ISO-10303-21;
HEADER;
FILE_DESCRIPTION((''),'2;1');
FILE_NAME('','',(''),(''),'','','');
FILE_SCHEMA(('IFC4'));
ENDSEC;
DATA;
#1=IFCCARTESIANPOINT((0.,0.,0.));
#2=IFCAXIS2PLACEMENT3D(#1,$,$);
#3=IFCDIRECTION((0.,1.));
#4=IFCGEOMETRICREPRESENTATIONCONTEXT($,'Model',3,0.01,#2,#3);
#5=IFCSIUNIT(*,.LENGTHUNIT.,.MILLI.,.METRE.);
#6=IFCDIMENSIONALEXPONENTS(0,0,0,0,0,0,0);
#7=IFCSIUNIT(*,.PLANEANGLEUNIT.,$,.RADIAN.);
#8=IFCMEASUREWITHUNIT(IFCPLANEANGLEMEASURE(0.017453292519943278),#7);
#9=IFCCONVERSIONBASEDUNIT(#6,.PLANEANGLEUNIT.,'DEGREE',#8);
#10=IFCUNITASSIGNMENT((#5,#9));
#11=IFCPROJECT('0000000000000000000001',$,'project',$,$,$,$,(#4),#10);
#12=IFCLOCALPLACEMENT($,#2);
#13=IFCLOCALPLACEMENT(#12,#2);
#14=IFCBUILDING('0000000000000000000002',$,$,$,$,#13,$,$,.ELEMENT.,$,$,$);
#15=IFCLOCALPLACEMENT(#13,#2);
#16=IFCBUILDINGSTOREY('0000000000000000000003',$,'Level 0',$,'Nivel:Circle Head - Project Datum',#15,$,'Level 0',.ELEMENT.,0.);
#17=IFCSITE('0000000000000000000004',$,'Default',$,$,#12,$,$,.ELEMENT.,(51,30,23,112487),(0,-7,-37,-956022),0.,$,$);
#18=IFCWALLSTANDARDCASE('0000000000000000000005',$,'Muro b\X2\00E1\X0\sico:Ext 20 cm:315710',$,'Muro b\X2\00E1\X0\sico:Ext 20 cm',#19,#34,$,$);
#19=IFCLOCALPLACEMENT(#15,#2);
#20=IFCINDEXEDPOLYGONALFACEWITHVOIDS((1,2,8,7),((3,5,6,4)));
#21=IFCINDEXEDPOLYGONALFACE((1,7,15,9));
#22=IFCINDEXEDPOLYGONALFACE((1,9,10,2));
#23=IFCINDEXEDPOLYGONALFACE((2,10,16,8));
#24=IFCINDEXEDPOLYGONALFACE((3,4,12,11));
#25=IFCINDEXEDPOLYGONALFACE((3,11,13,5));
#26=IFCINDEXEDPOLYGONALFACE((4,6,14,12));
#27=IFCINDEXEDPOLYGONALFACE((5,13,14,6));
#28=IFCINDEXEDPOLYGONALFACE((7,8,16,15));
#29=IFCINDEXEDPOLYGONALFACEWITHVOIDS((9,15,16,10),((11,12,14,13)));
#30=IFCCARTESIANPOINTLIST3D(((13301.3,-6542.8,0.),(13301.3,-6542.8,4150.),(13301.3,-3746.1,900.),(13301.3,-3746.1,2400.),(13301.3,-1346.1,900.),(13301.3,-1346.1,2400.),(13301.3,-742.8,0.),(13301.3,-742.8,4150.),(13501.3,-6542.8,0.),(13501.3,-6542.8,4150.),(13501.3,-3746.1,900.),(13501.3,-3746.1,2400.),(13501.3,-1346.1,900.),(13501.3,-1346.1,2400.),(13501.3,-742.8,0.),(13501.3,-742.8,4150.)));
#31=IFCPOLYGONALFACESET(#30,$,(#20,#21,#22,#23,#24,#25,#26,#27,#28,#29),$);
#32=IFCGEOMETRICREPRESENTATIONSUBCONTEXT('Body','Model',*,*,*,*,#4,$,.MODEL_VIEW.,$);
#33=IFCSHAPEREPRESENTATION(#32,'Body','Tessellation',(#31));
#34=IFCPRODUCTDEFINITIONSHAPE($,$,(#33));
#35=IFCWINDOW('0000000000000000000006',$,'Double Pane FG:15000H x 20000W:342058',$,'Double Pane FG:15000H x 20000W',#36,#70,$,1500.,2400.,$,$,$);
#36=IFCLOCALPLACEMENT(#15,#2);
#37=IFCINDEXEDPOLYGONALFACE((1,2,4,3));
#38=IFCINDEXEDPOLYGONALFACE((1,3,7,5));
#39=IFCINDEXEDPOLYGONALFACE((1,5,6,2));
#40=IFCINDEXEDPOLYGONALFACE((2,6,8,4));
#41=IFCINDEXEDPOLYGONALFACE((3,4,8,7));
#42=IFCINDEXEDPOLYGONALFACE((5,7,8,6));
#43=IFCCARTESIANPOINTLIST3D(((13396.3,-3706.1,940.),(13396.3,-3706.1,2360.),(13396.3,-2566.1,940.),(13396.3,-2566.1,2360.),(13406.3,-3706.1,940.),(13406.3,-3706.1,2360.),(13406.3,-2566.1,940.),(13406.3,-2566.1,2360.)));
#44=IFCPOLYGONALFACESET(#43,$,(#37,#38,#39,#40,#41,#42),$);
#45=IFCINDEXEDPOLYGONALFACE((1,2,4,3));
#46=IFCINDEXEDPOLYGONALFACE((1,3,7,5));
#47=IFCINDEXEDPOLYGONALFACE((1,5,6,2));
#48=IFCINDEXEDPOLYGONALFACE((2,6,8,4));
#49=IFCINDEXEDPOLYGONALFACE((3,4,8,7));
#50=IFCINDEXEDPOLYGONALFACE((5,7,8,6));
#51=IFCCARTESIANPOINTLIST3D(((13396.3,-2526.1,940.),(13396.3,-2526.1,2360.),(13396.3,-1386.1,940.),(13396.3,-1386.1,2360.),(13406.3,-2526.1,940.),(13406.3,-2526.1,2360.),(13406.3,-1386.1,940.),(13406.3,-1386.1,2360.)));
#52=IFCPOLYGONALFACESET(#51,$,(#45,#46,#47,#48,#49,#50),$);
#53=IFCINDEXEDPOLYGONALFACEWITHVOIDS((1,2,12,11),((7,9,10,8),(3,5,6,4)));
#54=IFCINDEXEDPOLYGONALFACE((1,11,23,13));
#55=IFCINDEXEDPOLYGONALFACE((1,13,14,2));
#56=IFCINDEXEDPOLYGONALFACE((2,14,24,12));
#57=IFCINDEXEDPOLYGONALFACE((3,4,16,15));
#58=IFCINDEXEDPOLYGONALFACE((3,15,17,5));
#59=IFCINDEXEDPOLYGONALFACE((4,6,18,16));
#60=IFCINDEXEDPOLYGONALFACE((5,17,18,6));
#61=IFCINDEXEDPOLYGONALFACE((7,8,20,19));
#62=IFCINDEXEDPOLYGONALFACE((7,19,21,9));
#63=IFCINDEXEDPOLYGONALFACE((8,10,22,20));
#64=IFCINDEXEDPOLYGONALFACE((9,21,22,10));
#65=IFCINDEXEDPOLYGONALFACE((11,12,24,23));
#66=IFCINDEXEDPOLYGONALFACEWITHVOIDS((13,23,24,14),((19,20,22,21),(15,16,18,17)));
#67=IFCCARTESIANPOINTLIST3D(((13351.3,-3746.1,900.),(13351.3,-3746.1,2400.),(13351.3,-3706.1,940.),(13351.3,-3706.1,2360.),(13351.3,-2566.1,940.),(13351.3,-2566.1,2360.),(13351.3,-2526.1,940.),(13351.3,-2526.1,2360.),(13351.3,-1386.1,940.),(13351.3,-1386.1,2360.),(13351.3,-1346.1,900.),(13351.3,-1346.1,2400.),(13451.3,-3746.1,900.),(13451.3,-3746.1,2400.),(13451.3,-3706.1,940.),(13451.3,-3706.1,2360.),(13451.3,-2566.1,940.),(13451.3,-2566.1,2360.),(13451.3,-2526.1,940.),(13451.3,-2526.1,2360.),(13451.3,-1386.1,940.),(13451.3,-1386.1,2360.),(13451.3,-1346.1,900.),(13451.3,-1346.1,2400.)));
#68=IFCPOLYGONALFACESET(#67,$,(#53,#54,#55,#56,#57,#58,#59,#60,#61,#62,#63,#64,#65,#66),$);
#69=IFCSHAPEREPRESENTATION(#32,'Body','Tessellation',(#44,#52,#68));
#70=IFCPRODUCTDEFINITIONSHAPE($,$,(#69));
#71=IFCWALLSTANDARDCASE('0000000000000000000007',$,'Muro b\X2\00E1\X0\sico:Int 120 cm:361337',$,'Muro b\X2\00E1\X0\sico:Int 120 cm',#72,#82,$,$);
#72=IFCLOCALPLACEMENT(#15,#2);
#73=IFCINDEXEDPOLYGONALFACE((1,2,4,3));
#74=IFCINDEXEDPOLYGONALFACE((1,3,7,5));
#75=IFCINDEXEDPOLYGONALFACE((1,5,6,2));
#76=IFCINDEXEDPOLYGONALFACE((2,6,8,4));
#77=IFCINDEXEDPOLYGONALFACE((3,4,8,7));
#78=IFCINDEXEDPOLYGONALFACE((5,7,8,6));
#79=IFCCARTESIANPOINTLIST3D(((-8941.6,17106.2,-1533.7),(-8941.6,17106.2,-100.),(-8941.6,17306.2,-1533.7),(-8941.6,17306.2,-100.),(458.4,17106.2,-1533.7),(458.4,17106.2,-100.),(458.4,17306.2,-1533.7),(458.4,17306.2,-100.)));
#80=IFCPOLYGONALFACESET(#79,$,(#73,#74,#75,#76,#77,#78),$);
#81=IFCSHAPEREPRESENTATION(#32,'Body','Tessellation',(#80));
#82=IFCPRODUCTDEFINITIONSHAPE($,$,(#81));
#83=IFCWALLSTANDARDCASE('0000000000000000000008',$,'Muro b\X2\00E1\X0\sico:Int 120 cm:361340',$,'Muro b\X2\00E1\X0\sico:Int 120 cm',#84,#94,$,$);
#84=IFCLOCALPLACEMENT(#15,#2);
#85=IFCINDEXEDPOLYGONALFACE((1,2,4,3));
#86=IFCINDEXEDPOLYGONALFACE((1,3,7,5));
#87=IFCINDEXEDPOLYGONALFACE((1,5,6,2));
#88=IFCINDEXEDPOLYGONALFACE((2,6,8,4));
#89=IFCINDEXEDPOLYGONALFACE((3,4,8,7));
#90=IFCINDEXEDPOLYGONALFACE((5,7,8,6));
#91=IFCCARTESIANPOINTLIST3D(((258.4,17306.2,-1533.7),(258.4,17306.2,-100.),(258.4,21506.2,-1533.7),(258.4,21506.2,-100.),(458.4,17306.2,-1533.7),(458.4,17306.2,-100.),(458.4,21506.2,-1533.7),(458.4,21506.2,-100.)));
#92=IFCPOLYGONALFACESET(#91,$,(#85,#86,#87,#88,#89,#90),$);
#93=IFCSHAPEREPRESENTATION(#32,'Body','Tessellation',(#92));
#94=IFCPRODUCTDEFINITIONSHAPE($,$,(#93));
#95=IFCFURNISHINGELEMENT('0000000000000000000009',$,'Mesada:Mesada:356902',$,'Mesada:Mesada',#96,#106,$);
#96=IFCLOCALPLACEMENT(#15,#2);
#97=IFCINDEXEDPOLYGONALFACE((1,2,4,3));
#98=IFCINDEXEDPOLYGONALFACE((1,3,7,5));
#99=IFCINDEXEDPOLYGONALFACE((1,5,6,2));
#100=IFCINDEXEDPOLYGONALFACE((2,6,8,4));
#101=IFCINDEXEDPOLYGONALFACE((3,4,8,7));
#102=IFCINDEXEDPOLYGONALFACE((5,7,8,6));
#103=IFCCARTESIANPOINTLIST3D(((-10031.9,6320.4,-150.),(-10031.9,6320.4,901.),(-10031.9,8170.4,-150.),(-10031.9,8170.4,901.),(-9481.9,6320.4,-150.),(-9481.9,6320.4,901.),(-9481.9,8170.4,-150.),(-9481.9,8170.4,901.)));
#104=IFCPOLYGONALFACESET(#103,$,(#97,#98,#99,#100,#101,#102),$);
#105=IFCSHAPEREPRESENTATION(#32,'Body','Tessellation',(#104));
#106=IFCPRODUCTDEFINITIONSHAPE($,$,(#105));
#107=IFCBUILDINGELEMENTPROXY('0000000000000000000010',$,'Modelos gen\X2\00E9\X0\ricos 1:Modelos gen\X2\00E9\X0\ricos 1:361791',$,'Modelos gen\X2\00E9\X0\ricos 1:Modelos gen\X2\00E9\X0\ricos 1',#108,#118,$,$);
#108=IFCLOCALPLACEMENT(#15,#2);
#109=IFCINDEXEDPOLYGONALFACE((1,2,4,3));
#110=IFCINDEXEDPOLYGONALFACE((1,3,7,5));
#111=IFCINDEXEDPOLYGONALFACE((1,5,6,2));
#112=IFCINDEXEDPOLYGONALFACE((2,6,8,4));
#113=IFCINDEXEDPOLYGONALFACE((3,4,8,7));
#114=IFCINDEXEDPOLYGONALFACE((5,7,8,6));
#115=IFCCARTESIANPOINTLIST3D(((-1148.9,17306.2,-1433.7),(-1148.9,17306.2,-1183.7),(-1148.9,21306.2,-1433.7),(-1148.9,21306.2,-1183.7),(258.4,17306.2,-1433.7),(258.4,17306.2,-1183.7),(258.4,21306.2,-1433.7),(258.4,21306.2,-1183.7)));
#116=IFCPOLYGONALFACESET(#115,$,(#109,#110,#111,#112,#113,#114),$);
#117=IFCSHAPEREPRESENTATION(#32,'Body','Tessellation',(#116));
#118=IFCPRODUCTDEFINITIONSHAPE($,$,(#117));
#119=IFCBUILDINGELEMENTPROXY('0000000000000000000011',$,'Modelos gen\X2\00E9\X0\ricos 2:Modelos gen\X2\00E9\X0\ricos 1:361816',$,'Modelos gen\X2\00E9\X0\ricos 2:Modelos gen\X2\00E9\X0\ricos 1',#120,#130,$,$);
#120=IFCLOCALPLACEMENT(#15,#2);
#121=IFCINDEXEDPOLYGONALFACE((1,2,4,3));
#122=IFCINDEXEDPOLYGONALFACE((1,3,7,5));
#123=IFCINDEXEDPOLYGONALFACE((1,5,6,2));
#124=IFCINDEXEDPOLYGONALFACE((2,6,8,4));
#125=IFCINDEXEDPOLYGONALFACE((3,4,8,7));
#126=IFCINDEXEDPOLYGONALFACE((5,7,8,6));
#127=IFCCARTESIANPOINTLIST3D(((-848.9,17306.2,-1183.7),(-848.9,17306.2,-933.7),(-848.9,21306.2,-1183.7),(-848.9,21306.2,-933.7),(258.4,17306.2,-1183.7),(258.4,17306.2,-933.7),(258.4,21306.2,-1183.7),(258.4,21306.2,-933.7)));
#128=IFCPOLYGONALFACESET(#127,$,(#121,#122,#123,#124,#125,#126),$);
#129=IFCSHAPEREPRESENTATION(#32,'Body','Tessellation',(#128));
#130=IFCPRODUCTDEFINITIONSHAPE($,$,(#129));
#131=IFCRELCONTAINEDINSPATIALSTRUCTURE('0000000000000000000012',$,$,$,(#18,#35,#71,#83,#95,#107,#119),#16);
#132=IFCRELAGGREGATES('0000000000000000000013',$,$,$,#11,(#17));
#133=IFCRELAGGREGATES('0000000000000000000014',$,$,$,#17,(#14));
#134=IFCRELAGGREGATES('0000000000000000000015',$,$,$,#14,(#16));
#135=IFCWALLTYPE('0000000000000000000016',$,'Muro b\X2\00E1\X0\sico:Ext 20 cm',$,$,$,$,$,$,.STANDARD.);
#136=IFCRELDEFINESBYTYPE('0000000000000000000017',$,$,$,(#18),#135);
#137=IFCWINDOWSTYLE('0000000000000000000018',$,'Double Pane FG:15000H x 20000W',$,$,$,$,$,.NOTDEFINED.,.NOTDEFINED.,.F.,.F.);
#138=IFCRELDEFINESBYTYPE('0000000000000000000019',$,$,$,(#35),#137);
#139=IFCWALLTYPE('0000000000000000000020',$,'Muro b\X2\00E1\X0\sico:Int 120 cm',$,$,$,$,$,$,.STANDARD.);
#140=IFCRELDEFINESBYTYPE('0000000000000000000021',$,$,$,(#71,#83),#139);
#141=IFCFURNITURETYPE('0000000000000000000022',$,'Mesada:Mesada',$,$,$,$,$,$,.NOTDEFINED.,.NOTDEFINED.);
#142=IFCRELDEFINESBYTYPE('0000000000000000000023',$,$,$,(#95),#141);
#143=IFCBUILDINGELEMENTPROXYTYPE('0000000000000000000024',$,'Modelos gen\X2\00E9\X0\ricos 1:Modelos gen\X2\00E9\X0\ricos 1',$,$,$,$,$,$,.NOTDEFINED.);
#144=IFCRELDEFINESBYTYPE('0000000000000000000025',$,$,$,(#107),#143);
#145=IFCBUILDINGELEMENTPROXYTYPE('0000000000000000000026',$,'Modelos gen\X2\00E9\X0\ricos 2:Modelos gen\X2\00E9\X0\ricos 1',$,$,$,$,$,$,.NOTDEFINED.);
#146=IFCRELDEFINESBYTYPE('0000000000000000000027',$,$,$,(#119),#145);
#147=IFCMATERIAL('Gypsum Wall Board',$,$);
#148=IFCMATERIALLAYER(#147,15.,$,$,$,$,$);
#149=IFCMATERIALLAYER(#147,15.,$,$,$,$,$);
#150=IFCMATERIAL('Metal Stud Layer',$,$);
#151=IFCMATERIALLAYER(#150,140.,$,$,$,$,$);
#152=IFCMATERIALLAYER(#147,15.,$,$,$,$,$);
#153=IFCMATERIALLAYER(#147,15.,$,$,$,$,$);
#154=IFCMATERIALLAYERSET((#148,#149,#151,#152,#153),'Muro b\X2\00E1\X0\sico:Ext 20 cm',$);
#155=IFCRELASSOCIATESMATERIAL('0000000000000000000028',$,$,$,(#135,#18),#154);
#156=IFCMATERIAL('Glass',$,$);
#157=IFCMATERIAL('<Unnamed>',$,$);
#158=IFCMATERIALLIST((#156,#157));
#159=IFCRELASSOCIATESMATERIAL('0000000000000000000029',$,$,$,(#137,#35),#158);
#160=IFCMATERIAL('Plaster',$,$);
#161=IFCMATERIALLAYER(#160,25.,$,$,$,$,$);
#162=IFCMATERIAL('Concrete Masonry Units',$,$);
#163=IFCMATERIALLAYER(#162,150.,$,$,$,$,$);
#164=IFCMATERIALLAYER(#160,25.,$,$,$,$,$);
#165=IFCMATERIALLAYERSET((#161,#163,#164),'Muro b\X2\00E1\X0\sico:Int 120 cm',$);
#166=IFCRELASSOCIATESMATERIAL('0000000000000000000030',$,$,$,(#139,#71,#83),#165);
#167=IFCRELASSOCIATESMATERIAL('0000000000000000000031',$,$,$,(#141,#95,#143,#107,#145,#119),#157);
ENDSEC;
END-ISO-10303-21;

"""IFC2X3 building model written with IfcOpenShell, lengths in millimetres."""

from ifc_helpers import new_model, entity, si_unit, converted_unit, direction, frame, frame_2d, origin, origin_2d_with_axis, place, context, subcontext, project, spatial, polyline, rectangle, outline, extrude, clip, bounded_halfspace, source, transform, mapped, material, material_list, layer, layer_set, layer_usage, type_object, type_shapes, element, fill, save


model = new_model("IFC2X3")

# Units and contexts
model_context = context("Model", 3, precision=0.01, world=origin(), true_north=direction((0.0, 1.0)))
body_context = subcontext(model_context, "Body", "Model", "MODEL_VIEW")
ifc_project = project(units=[si_unit("LENGTHUNIT", "METRE", prefix="MILLI"), converted_unit("PLANEANGLEUNIT", "DEGREE", entity("IfcPlaneAngleMeasure", 0.017453292519943278), si_unit("PLANEANGLEUNIT", "RADIAN"), dimensions=[0, 0, 0, 0, 0, 0, 0])], contexts=[model_context])

# Site, building, storey
site_placement = place(None, origin())
site = spatial("IfcSite", under=ifc_project, at=site_placement, Name="Default", CompositionType="ELEMENT", RefLatitude=(51, 30, 23, 112487), RefLongitude=(0, -7, -37, -956022), RefElevation=0.0)
building_placement = place(site_placement, origin())
building = spatial("IfcBuilding", under=site, at=building_placement, CompositionType="ELEMENT")
storey_placement = place(building_placement, origin())
storey = spatial("IfcBuildingStorey", under=building, at=storey_placement, Name="Level 0", ObjectType="Nivel:Circle Head - Project Datum", LongName="Level 0", CompositionType="ELEMENT", Elevation=0.0)

# Shared definitions
ifc_material_1 = material(Name="Gypsum Wall Board")
ifc_layer_1 = layer(ifc_material_1, 15.0)
ifc_layer_2 = layer(ifc_material_1, 15.0)
ifc_material_2 = material(Name="Metal Stud Layer")
ifc_layer_3 = layer(ifc_material_2, 140.0)
ifc_layer_4 = layer(ifc_material_1, 15.0)
ifc_layer_5 = layer(ifc_material_1, 15.0)
ifc_layer_set_1 = layer_set([ifc_layer_1, ifc_layer_2, ifc_layer_3, ifc_layer_4, ifc_layer_5], Name="Muro básico:Ext 20 cm")
wall_type_1 = type_object("IfcWallType", Name="Muro básico:Ext 20 cm", PredefinedType="STANDARD", material=ifc_layer_set_1)
ifc_material_3 = material(Name="<Unnamed>")
ifc_material_4 = material(Name="Glass")

# Wall, opening, window
ifc_material_list_1 = material_list([ifc_material_4, ifc_material_3])
ifc_layer_usage_1 = layer_usage(ifc_layer_set_1, "AXIS2", "NEGATIVE", 100.0)
wall_1_placement = place(storey_placement, frame((13401.3, -742.8, 0.0), z_axis=(0.0, 0.0, 1.0), x_axis=(0.0, -1.0, 0.0)))
wall_1 = element("IfcWallStandardCase", 1, at=wall_1_placement, inside=storey, type_object=wall_type_1, material=ifc_layer_usage_1, Name="Muro básico:Ext 20 cm:315710", ObjectType="Muro básico:Ext 20 cm", context=body_context, shape_type="SweptSolid", body=[
    extrude(rectangle(XDim=5800.0, YDim=200.0, at=frame_2d((2900.0, 0.0), x_axis=(-1.0, 0.0))), origin(), (0.0, 0.0, 1.0), 4150.0),
])
opening_1_placement = place(wall_1_placement, frame((603.3, -100.0, 900.0)))
opening_1 = element("IfcOpeningElement", 2, at=opening_1_placement, cuts=wall_1, ObjectType="Opening", context=body_context, shape_type="SweptSolid", body=[
    extrude(rectangle(XDim=1500.0, YDim=2400.0, at=frame_2d((750.0, 1200.0), x_axis=(1.0, 0.0))), frame((0.0, 0.0, 0.0), z_axis=(0.0, 1.0, 0.0), x_axis=(0.0, 0.0, 1.0)), (0.0, 0.0, 1.0), 200.0),
])
window_style_1 = type_object("IfcWindowStyle", Name="Double Pane FG:15000H x 20000W", ConstructionType="NOTDEFINED", OperationType="NOTDEFINED", ParameterTakesPrecedence=False, Sizeable=False, material=ifc_material_list_1)
shared_shape_1 = source(origin(), body_context, "Body", "SweptSolid", [
    extrude(rectangle(XDim=10.0, YDim=1140.0, at=origin_2d_with_axis()), frame((1790.0, 100.0, 40.0), z_axis=(0.0, 0.0, 1.0), x_axis=(0.0, 1.0, 0.0)), (0.0, 0.0, 1.0), 1420.0),
    extrude(rectangle(XDim=10.0, YDim=1140.0, at=origin_2d_with_axis()), frame((610.0, 100.0, 40.0), z_axis=(0.0, 0.0, 1.0), x_axis=(0.0, 1.0, 0.0)), (0.0, 0.0, 1.0), 1420.0),
    extrude(outline(polyline([(-750.0, -1200.0), (750.0, -1200.0), (750.0, 1200.0), (-750.0, 1200.0), (-750.0, -1200.0)]), holes=[polyline([(710.0, -20.0), (710.0, -1160.0), (-710.0, -1160.0), (-710.0, -20.0), (710.0, -20.0)]), polyline([(-710.0, 20.0), (-710.0, 1160.0), (710.0, 1160.0), (710.0, 20.0), (-710.0, 20.0)])]), frame((1200.0, 50.0, 750.0), z_axis=(0.0, 1.0, 0.0), x_axis=(0.0, 0.0, -1.0)), (0.0, 0.0, 1.0), 100.0),
])
type_shapes(window_style_1, [shared_shape_1])
window_1_placement = place(opening_1_placement, origin())
window_1 = element("IfcWindow", 3, at=window_1_placement, inside=storey, type_object=window_style_1, material=ifc_material_list_1, Name="Double Pane FG:15000H x 20000W:342058", ObjectType="Double Pane FG:15000H x 20000W", OverallHeight=1500.0, OverallWidth=2400.0, context=body_context, shape_type="MappedRepresentation", body=[
    mapped(shared_shape_1, transform((0.0, 0.0, 0.0), scale=1.0)),
])
fill(opening_1, window_1)

# Walls
ifc_material_5 = material(Name="Plaster")
ifc_layer_6 = layer(ifc_material_5, 25.0)
ifc_material_6 = material(Name="Concrete Masonry Units")
ifc_layer_7 = layer(ifc_material_6, 150.0)
ifc_layer_8 = layer(ifc_material_5, 25.0)
ifc_layer_set_2 = layer_set([ifc_layer_6, ifc_layer_7, ifc_layer_8], Name="Muro básico:Int 120 cm")
ifc_layer_usage_2 = layer_usage(ifc_layer_set_2, "AXIS2", "NEGATIVE", 100.0)
wall_type_2 = type_object("IfcWallType", Name="Muro básico:Int 120 cm", PredefinedType="STANDARD", material=ifc_layer_set_2)
wall_2_placement = place(storey_placement, frame((458.4, 17206.2, -1533.7), z_axis=(0.0, 0.0, 1.0), x_axis=(-1.0, 0.0, 0.0)))
element("IfcWallStandardCase", 4, at=wall_2_placement, inside=storey, type_object=wall_type_2, material=ifc_layer_usage_2, Name="Muro básico:Int 120 cm:361337", ObjectType="Muro básico:Int 120 cm", context=body_context, shape_type="SweptSolid", body=[
    extrude(rectangle(XDim=9400.0, YDim=200.0, at=frame_2d((4700.0, 0.0), x_axis=(-1.0, 0.0))), origin(), (0.0, 0.0, 1.0), 1433.7),
])
ifc_layer_usage_3 = layer_usage(ifc_layer_set_2, "AXIS2", "POSITIVE", -100.0)
wall_3_placement = place(storey_placement, frame((358.4, 21506.2, -1533.7), z_axis=(0.0, 0.0, 1.0), x_axis=(0.0, -1.0, 0.0)))
element("IfcWallStandardCase", 5, at=wall_3_placement, inside=storey, type_object=wall_type_2, material=ifc_layer_usage_3, Name="Muro básico:Int 120 cm:361340", ObjectType="Muro básico:Int 120 cm", context=body_context, shape_type="Clipping", body=[
    clip(extrude(rectangle(XDim=4200.0, YDim=200.0, at=frame_2d((2100.0, 0.0), x_axis=(-1.0, 0.0))), origin(), (0.0, 0.0, 1.0), 1433.7), bounded_halfspace(frame((200.0, -100.0, 1433.7), z_axis=(0.0, 0.0, -1.0), x_axis=(-1.0, 0.0, 0.0)), True, frame((200.0, -100.0, 1433.7), z_axis=(0.0, 0.0, -1.0), x_axis=(-1.0, 0.0, 0.0)), polyline([(0.0, 0.0), (200.0, 0.0), (200.0, 200.0), (-4000.0, 200.0), (-4000.0, 0.0), (0.0, 0.0)]))),
])

# Furnishing element
furniture_type = type_object("IfcFurnitureType", Name="Mesada:Mesada", AssemblyPlace="NOTDEFINED", material=ifc_material_3)
shared_shape_2 = source(origin(), body_context, "Body", "SweptSolid", [
    extrude(rectangle(XDim=1850.0, YDim=550.0, at=frame_2d((0.0, 0.0), x_axis=(1.0, 0.0))), frame((-9756.9, 7245.4, -150.0), z_axis=(0.0, 0.0, 1.0), x_axis=(0.0, -1.0, 0.0)), (0.0, 0.0, 1.0), 1051.0),
])
type_shapes(furniture_type, [shared_shape_2])
furnishing_placement = place(storey_placement, origin())
element("IfcFurnishingElement", 6, at=furnishing_placement, inside=storey, type_object=furniture_type, material=ifc_material_3, Name="Mesada:Mesada:356902", ObjectType="Mesada:Mesada", context=body_context, shape_type="MappedRepresentation", body=[
    mapped(shared_shape_2, transform((0.0, 0.0, 0.0), scale=1.0)),
])

# Building element proxies
building_element_proxy_type_1 = type_object("IfcBuildingElementProxyType", Name="Modelos genéricos 1:Modelos genéricos 1", PredefinedType="NOTDEFINED", material=ifc_material_3)
shared_shape_3 = source(origin(), body_context, "Body", "SweptSolid", [
    extrude(rectangle(XDim=4000.0, YDim=1407.2, at=origin_2d_with_axis()), frame((-445.2, 19306.2, -1433.7), z_axis=(0.0, 0.0, 1.0), x_axis=(0.0, -1.0, 0.0)), (0.0, 0.0, 1.0), 250.0),
])
type_shapes(building_element_proxy_type_1, [shared_shape_3])
proxy_1_placement = place(storey_placement, origin())
element("IfcBuildingElementProxy", 7, at=proxy_1_placement, inside=storey, type_object=building_element_proxy_type_1, material=ifc_material_3, Name="Modelos genéricos 1:Modelos genéricos 1:361791", ObjectType="Modelos genéricos 1:Modelos genéricos 1", context=body_context, shape_type="MappedRepresentation", body=[
    mapped(shared_shape_3, transform((0.0, 0.0, 0.0), scale=1.0)),
])
building_element_proxy_type_2 = type_object("IfcBuildingElementProxyType", Name="Modelos genéricos 2:Modelos genéricos 1", PredefinedType="NOTDEFINED", material=ifc_material_3)
shared_shape_4 = source(origin(), body_context, "Body", "SweptSolid", [
    extrude(rectangle(XDim=4000.0, YDim=1107.2, at=frame_2d((0.0, 0.0), x_axis=(1.0, 0.0))), frame((-295.2, 19306.2, -1183.7), z_axis=(0.0, 0.0, 1.0), x_axis=(0.0, -1.0, 0.0)), (0.0, 0.0, 1.0), 250.0),
])
type_shapes(building_element_proxy_type_2, [shared_shape_4])
proxy_2_placement = place(storey_placement, origin())
element("IfcBuildingElementProxy", 8, at=proxy_2_placement, inside=storey, type_object=building_element_proxy_type_2, material=ifc_material_3, Name="Modelos genéricos 2:Modelos genéricos 1:361816", ObjectType="Modelos genéricos 2:Modelos genéricos 1", context=body_context, shape_type="MappedRepresentation", body=[
    mapped(shared_shape_4, transform((0.0, 0.0, 0.0), scale=1.0)),
])

save(model, "model.ifc")
